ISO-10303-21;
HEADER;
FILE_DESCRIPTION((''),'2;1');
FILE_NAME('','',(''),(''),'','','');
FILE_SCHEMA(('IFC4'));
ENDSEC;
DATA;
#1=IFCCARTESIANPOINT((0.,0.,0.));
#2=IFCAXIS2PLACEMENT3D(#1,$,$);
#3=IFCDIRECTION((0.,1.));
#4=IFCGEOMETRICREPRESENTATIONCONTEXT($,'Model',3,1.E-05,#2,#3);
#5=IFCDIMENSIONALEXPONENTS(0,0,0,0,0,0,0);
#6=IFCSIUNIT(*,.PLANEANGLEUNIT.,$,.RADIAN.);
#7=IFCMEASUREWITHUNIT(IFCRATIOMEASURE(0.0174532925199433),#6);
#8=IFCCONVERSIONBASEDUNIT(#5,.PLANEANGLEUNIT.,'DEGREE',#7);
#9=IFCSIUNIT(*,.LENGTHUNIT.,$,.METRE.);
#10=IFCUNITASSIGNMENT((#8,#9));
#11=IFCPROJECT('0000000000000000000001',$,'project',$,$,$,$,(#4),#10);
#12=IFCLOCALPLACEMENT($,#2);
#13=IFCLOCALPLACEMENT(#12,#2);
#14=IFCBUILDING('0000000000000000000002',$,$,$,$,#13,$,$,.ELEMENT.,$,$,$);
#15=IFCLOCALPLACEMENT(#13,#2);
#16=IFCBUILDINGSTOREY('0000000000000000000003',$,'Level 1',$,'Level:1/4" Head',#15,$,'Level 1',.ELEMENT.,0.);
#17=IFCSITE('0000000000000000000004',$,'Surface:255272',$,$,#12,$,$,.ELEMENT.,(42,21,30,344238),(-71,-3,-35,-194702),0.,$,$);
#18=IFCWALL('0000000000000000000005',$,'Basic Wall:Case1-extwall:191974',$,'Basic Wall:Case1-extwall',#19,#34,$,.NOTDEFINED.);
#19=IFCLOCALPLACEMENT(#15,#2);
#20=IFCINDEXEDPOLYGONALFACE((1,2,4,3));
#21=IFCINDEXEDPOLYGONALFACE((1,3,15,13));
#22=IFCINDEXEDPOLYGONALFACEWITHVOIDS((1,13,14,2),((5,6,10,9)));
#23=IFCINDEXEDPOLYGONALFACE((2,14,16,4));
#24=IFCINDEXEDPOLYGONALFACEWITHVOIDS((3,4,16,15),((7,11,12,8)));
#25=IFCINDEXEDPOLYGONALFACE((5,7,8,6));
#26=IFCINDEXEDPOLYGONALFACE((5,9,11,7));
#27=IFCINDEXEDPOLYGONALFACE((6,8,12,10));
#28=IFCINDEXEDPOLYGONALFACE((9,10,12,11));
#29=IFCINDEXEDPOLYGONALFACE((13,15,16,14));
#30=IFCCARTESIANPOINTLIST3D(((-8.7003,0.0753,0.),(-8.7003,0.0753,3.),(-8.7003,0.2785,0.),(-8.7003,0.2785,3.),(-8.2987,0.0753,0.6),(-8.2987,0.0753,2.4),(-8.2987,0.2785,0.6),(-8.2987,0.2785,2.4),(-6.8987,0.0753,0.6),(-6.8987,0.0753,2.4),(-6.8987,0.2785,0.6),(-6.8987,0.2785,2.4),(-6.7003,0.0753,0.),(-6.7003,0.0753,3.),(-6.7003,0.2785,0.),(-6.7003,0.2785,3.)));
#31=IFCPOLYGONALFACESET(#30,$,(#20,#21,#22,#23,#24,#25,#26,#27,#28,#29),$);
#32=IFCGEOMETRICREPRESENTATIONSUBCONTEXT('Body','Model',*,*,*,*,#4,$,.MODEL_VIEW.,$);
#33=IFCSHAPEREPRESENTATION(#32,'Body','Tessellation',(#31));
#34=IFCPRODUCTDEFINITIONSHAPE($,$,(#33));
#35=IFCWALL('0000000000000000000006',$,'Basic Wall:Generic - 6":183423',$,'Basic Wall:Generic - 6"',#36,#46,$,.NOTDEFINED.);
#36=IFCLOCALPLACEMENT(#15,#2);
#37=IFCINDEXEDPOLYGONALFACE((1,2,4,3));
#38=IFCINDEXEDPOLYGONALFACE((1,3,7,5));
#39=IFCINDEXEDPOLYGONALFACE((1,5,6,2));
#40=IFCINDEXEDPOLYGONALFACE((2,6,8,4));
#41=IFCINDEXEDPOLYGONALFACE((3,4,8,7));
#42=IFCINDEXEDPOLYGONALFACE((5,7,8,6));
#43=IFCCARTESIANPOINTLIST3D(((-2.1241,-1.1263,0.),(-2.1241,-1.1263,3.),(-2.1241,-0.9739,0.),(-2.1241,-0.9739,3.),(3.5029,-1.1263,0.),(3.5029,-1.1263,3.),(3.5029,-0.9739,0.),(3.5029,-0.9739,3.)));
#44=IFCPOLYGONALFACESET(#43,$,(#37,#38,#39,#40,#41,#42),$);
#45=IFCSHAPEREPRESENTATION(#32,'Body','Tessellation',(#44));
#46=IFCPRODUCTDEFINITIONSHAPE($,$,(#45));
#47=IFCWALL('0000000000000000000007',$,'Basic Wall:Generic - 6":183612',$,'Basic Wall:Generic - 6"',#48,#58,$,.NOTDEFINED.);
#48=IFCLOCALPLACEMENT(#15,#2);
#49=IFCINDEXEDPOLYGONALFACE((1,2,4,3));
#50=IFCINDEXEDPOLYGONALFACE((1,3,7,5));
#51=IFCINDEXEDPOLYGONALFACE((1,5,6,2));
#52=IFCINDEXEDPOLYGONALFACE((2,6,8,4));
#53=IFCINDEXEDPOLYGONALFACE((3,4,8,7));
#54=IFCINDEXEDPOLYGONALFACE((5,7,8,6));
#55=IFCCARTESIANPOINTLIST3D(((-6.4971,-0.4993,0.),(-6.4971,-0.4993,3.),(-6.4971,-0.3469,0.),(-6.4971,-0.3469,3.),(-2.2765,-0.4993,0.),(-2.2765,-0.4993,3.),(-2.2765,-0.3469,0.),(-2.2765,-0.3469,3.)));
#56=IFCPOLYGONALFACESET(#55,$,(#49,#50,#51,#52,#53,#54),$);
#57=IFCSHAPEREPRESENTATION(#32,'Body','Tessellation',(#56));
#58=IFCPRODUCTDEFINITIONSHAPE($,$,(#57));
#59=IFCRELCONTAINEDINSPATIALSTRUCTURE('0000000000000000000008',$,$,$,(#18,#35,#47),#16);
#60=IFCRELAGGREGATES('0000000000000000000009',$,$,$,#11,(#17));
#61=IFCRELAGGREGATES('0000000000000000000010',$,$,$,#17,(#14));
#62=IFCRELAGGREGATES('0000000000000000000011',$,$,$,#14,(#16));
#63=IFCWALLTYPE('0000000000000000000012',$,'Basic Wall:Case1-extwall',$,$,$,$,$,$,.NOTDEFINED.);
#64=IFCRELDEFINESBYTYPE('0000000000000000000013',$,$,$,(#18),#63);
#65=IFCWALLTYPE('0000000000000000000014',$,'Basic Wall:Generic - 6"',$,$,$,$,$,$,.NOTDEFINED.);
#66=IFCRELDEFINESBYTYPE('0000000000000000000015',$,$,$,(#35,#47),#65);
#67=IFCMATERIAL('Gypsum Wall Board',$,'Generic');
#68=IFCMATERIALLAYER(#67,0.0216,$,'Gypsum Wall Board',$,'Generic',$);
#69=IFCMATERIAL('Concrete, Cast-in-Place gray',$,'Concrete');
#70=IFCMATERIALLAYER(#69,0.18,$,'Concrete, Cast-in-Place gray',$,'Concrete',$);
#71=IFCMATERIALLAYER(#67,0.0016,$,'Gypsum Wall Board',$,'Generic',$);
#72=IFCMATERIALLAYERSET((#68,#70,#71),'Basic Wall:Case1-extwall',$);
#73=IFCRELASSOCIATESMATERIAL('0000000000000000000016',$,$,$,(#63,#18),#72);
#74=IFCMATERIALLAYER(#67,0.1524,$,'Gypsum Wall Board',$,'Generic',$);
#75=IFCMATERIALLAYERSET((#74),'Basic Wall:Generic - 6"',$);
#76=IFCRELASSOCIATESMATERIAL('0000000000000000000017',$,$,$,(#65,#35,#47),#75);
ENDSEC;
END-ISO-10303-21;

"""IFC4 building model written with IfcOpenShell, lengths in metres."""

from ifc_helpers import new_model, entity, si_unit, converted_unit, direction, frame, frame_2d, origin, place, context, subcontext, project, spatial, polyline, rectangle, extrude, clip, bounded_halfspace, material, layer, layer_set, layer_usage, type_object, element, save


model = new_model("IFC4")

# Units and contexts
model_context = context("Model", 3, precision=1e-05, world=origin(), true_north=direction((0.0, 1.0)))
body_context = subcontext(model_context, "Body", "Model", "MODEL_VIEW")
ifc_project = project(units=[converted_unit("PLANEANGLEUNIT", "DEGREE", entity("IfcRatioMeasure", 0.0174532925199433), si_unit("PLANEANGLEUNIT", "RADIAN"), dimensions=[0, 0, 0, 0, 0, 0, 0]), si_unit("LENGTHUNIT", "METRE")], contexts=[model_context])

# Site, building, storey
site_placement = place(None, origin())
site = spatial("IfcSite", under=ifc_project, at=site_placement, Name="Surface:255272", CompositionType="ELEMENT", RefLatitude=(42, 21, 30, 344238), RefLongitude=(-71, -3, -35, -194702), RefElevation=0.0)
building_placement = place(site_placement, origin())
building = spatial("IfcBuilding", under=site, at=building_placement, CompositionType="ELEMENT")
storey_placement = place(building_placement, origin())
storey = spatial("IfcBuildingStorey", under=building, at=storey_placement, Name="Level 1", ObjectType="Level:1/4\" Head", LongName="Level 1", CompositionType="ELEMENT", Elevation=0.0)

# Shared definitions
ifc_material_1 = material(Name="Gypsum Wall Board", Category="Generic")
ifc_layer_1 = layer(ifc_material_1, 0.0216, Name="Gypsum Wall Board", Category="Generic")
ifc_material_2 = material(Name="Concrete, Cast-in-Place gray", Category="Concrete")
ifc_layer_2 = layer(ifc_material_2, 0.18, Name="Concrete, Cast-in-Place gray", Category="Concrete")
ifc_layer_3 = layer(ifc_material_1, 0.0016, Name="Gypsum Wall Board", Category="Generic")
ifc_layer_set_1 = layer_set([ifc_layer_1, ifc_layer_2, ifc_layer_3], Name="Basic Wall:Case1-extwall")
wall_type_1 = type_object("IfcWallType", Name="Basic Wall:Case1-extwall", PredefinedType="NOTDEFINED", material=ifc_layer_set_1)

# Wall, opening
ifc_layer_usage_1 = layer_usage(ifc_layer_set_1, "AXIS2", "NEGATIVE", 0.1016)
wall_1_placement = place(storey_placement, frame((-6.7003, 0.1769, 0.0), z_axis=(0.0, 0.0, 1.0), x_axis=(-1.0, 0.000007, 0.0)))
wall_1 = element("IfcWall", 1, at=wall_1_placement, inside=storey, type_object=wall_type_1, material=ifc_layer_usage_1, Name="Basic Wall:Case1-extwall:191974", ObjectType="Basic Wall:Case1-extwall", PredefinedType="NOTDEFINED", context=body_context, shape_type="Clipping", body=[
    clip(extrude(rectangle(XDim=2.0, YDim=0.2032, at=frame_2d((1.0, 0.0), x_axis=(-1.0, 0.0))), origin(), (0.0, 0.0, 1.0), 3.0), bounded_halfspace(frame((0.0, -0.1016, 3.0), z_axis=(0.0, 0.0, -1.0), x_axis=(1.0, 0.0, 0.0)), True, frame((0.0, -0.1016, 3.0)), polyline([(0.0, 0.0), (1.7968, 0.0), (2.0, 0.0), (2.0, 0.2032), (0.0, 0.2032), (0.0, 0.0)]))),
])
opening_1_placement = place(wall_1_placement, frame((1.5984, 0.1016, 0.6)))
element("IfcOpeningElement", 2, at=opening_1_placement, cuts=wall_1, ObjectType="Opening", PredefinedType="OPENING", context=body_context, shape_type="SweptSolid", body=[
    extrude(rectangle(XDim=1.8, YDim=1.4, at=frame_2d((0.0, 0.0), x_axis=(1.0, 0.0))), frame((-0.7, -0.2032, 0.9), z_axis=(0.0, 1.0, 0.0), x_axis=(0.0, 0.0, -1.0)), (0.0, 0.0, 1.0), 0.2032),
])

# Walls
ifc_layer_4 = layer(ifc_material_1, 0.1524, Name="Gypsum Wall Board", Category="Generic")
ifc_layer_set_2 = layer_set([ifc_layer_4], Name="Basic Wall:Generic - 6\"")
ifc_layer_usage_2 = layer_usage(ifc_layer_set_2, "AXIS2", "NEGATIVE", 0.0762)
wall_type_2 = type_object("IfcWallType", Name="Basic Wall:Generic - 6\"", PredefinedType="NOTDEFINED", material=ifc_layer_set_2)
wall_2_placement = place(storey_placement, frame((-2.1241, -1.0501, 0.0)))
element("IfcWall", 3, at=wall_2_placement, inside=storey, type_object=wall_type_2, material=ifc_layer_usage_2, Name="Basic Wall:Generic - 6\":183423", ObjectType="Basic Wall:Generic - 6\"", PredefinedType="NOTDEFINED", context=body_context, shape_type="Clipping", body=[
    clip(extrude(rectangle(XDim=5.627, YDim=0.1524, at=frame_2d((2.8135, 0.0), x_axis=(-1.0, 0.0))), origin(), (0.0, 0.0, 1.0), 3.0), bounded_halfspace(frame((0.0, -0.0762, 3.0), z_axis=(0.0, 0.0, -1.0), x_axis=(-1.0, 0.0, 0.0)), True, frame((0.0, -0.0762, 3.0)), polyline([(0.0, 0.0), (5.627, 0.0), (5.627, 0.1524), (0.0, 0.1524), (0.0, 0.0)]))),
])
ifc_layer_usage_3 = layer_usage(ifc_layer_set_2, "AXIS2", "NEGATIVE", 0.0762)
wall_3_placement = place(storey_placement, frame((-2.2765, -0.4231, 0.0), z_axis=(0.0, 0.0, 1.0), x_axis=(-1.0, 0.000007, 0.0)))
element("IfcWall", 4, at=wall_3_placement, inside=storey, type_object=wall_type_2, material=ifc_layer_usage_3, Name="Basic Wall:Generic - 6\":183612", ObjectType="Basic Wall:Generic - 6\"", PredefinedType="NOTDEFINED", context=body_context, shape_type="Clipping", body=[
    clip(extrude(rectangle(XDim=4.2206, YDim=0.1524, at=frame_2d((2.1103, 0.0), x_axis=(-1.0, 0.0))), origin(), (0.0, 0.0, 1.0), 3.0), bounded_halfspace(frame((0.0, -0.0762, 3.0), z_axis=(0.0, 0.0, -1.0), x_axis=(1.0, 0.0, 0.0)), True, frame((0.0, -0.0762, 3.0)), polyline([(0.0, 0.0), (4.2206, 0.0), (4.2206, 0.1524), (0.0, 0.1524), (0.0, 0.0)]))),
])

save(model, "model.ifc")
